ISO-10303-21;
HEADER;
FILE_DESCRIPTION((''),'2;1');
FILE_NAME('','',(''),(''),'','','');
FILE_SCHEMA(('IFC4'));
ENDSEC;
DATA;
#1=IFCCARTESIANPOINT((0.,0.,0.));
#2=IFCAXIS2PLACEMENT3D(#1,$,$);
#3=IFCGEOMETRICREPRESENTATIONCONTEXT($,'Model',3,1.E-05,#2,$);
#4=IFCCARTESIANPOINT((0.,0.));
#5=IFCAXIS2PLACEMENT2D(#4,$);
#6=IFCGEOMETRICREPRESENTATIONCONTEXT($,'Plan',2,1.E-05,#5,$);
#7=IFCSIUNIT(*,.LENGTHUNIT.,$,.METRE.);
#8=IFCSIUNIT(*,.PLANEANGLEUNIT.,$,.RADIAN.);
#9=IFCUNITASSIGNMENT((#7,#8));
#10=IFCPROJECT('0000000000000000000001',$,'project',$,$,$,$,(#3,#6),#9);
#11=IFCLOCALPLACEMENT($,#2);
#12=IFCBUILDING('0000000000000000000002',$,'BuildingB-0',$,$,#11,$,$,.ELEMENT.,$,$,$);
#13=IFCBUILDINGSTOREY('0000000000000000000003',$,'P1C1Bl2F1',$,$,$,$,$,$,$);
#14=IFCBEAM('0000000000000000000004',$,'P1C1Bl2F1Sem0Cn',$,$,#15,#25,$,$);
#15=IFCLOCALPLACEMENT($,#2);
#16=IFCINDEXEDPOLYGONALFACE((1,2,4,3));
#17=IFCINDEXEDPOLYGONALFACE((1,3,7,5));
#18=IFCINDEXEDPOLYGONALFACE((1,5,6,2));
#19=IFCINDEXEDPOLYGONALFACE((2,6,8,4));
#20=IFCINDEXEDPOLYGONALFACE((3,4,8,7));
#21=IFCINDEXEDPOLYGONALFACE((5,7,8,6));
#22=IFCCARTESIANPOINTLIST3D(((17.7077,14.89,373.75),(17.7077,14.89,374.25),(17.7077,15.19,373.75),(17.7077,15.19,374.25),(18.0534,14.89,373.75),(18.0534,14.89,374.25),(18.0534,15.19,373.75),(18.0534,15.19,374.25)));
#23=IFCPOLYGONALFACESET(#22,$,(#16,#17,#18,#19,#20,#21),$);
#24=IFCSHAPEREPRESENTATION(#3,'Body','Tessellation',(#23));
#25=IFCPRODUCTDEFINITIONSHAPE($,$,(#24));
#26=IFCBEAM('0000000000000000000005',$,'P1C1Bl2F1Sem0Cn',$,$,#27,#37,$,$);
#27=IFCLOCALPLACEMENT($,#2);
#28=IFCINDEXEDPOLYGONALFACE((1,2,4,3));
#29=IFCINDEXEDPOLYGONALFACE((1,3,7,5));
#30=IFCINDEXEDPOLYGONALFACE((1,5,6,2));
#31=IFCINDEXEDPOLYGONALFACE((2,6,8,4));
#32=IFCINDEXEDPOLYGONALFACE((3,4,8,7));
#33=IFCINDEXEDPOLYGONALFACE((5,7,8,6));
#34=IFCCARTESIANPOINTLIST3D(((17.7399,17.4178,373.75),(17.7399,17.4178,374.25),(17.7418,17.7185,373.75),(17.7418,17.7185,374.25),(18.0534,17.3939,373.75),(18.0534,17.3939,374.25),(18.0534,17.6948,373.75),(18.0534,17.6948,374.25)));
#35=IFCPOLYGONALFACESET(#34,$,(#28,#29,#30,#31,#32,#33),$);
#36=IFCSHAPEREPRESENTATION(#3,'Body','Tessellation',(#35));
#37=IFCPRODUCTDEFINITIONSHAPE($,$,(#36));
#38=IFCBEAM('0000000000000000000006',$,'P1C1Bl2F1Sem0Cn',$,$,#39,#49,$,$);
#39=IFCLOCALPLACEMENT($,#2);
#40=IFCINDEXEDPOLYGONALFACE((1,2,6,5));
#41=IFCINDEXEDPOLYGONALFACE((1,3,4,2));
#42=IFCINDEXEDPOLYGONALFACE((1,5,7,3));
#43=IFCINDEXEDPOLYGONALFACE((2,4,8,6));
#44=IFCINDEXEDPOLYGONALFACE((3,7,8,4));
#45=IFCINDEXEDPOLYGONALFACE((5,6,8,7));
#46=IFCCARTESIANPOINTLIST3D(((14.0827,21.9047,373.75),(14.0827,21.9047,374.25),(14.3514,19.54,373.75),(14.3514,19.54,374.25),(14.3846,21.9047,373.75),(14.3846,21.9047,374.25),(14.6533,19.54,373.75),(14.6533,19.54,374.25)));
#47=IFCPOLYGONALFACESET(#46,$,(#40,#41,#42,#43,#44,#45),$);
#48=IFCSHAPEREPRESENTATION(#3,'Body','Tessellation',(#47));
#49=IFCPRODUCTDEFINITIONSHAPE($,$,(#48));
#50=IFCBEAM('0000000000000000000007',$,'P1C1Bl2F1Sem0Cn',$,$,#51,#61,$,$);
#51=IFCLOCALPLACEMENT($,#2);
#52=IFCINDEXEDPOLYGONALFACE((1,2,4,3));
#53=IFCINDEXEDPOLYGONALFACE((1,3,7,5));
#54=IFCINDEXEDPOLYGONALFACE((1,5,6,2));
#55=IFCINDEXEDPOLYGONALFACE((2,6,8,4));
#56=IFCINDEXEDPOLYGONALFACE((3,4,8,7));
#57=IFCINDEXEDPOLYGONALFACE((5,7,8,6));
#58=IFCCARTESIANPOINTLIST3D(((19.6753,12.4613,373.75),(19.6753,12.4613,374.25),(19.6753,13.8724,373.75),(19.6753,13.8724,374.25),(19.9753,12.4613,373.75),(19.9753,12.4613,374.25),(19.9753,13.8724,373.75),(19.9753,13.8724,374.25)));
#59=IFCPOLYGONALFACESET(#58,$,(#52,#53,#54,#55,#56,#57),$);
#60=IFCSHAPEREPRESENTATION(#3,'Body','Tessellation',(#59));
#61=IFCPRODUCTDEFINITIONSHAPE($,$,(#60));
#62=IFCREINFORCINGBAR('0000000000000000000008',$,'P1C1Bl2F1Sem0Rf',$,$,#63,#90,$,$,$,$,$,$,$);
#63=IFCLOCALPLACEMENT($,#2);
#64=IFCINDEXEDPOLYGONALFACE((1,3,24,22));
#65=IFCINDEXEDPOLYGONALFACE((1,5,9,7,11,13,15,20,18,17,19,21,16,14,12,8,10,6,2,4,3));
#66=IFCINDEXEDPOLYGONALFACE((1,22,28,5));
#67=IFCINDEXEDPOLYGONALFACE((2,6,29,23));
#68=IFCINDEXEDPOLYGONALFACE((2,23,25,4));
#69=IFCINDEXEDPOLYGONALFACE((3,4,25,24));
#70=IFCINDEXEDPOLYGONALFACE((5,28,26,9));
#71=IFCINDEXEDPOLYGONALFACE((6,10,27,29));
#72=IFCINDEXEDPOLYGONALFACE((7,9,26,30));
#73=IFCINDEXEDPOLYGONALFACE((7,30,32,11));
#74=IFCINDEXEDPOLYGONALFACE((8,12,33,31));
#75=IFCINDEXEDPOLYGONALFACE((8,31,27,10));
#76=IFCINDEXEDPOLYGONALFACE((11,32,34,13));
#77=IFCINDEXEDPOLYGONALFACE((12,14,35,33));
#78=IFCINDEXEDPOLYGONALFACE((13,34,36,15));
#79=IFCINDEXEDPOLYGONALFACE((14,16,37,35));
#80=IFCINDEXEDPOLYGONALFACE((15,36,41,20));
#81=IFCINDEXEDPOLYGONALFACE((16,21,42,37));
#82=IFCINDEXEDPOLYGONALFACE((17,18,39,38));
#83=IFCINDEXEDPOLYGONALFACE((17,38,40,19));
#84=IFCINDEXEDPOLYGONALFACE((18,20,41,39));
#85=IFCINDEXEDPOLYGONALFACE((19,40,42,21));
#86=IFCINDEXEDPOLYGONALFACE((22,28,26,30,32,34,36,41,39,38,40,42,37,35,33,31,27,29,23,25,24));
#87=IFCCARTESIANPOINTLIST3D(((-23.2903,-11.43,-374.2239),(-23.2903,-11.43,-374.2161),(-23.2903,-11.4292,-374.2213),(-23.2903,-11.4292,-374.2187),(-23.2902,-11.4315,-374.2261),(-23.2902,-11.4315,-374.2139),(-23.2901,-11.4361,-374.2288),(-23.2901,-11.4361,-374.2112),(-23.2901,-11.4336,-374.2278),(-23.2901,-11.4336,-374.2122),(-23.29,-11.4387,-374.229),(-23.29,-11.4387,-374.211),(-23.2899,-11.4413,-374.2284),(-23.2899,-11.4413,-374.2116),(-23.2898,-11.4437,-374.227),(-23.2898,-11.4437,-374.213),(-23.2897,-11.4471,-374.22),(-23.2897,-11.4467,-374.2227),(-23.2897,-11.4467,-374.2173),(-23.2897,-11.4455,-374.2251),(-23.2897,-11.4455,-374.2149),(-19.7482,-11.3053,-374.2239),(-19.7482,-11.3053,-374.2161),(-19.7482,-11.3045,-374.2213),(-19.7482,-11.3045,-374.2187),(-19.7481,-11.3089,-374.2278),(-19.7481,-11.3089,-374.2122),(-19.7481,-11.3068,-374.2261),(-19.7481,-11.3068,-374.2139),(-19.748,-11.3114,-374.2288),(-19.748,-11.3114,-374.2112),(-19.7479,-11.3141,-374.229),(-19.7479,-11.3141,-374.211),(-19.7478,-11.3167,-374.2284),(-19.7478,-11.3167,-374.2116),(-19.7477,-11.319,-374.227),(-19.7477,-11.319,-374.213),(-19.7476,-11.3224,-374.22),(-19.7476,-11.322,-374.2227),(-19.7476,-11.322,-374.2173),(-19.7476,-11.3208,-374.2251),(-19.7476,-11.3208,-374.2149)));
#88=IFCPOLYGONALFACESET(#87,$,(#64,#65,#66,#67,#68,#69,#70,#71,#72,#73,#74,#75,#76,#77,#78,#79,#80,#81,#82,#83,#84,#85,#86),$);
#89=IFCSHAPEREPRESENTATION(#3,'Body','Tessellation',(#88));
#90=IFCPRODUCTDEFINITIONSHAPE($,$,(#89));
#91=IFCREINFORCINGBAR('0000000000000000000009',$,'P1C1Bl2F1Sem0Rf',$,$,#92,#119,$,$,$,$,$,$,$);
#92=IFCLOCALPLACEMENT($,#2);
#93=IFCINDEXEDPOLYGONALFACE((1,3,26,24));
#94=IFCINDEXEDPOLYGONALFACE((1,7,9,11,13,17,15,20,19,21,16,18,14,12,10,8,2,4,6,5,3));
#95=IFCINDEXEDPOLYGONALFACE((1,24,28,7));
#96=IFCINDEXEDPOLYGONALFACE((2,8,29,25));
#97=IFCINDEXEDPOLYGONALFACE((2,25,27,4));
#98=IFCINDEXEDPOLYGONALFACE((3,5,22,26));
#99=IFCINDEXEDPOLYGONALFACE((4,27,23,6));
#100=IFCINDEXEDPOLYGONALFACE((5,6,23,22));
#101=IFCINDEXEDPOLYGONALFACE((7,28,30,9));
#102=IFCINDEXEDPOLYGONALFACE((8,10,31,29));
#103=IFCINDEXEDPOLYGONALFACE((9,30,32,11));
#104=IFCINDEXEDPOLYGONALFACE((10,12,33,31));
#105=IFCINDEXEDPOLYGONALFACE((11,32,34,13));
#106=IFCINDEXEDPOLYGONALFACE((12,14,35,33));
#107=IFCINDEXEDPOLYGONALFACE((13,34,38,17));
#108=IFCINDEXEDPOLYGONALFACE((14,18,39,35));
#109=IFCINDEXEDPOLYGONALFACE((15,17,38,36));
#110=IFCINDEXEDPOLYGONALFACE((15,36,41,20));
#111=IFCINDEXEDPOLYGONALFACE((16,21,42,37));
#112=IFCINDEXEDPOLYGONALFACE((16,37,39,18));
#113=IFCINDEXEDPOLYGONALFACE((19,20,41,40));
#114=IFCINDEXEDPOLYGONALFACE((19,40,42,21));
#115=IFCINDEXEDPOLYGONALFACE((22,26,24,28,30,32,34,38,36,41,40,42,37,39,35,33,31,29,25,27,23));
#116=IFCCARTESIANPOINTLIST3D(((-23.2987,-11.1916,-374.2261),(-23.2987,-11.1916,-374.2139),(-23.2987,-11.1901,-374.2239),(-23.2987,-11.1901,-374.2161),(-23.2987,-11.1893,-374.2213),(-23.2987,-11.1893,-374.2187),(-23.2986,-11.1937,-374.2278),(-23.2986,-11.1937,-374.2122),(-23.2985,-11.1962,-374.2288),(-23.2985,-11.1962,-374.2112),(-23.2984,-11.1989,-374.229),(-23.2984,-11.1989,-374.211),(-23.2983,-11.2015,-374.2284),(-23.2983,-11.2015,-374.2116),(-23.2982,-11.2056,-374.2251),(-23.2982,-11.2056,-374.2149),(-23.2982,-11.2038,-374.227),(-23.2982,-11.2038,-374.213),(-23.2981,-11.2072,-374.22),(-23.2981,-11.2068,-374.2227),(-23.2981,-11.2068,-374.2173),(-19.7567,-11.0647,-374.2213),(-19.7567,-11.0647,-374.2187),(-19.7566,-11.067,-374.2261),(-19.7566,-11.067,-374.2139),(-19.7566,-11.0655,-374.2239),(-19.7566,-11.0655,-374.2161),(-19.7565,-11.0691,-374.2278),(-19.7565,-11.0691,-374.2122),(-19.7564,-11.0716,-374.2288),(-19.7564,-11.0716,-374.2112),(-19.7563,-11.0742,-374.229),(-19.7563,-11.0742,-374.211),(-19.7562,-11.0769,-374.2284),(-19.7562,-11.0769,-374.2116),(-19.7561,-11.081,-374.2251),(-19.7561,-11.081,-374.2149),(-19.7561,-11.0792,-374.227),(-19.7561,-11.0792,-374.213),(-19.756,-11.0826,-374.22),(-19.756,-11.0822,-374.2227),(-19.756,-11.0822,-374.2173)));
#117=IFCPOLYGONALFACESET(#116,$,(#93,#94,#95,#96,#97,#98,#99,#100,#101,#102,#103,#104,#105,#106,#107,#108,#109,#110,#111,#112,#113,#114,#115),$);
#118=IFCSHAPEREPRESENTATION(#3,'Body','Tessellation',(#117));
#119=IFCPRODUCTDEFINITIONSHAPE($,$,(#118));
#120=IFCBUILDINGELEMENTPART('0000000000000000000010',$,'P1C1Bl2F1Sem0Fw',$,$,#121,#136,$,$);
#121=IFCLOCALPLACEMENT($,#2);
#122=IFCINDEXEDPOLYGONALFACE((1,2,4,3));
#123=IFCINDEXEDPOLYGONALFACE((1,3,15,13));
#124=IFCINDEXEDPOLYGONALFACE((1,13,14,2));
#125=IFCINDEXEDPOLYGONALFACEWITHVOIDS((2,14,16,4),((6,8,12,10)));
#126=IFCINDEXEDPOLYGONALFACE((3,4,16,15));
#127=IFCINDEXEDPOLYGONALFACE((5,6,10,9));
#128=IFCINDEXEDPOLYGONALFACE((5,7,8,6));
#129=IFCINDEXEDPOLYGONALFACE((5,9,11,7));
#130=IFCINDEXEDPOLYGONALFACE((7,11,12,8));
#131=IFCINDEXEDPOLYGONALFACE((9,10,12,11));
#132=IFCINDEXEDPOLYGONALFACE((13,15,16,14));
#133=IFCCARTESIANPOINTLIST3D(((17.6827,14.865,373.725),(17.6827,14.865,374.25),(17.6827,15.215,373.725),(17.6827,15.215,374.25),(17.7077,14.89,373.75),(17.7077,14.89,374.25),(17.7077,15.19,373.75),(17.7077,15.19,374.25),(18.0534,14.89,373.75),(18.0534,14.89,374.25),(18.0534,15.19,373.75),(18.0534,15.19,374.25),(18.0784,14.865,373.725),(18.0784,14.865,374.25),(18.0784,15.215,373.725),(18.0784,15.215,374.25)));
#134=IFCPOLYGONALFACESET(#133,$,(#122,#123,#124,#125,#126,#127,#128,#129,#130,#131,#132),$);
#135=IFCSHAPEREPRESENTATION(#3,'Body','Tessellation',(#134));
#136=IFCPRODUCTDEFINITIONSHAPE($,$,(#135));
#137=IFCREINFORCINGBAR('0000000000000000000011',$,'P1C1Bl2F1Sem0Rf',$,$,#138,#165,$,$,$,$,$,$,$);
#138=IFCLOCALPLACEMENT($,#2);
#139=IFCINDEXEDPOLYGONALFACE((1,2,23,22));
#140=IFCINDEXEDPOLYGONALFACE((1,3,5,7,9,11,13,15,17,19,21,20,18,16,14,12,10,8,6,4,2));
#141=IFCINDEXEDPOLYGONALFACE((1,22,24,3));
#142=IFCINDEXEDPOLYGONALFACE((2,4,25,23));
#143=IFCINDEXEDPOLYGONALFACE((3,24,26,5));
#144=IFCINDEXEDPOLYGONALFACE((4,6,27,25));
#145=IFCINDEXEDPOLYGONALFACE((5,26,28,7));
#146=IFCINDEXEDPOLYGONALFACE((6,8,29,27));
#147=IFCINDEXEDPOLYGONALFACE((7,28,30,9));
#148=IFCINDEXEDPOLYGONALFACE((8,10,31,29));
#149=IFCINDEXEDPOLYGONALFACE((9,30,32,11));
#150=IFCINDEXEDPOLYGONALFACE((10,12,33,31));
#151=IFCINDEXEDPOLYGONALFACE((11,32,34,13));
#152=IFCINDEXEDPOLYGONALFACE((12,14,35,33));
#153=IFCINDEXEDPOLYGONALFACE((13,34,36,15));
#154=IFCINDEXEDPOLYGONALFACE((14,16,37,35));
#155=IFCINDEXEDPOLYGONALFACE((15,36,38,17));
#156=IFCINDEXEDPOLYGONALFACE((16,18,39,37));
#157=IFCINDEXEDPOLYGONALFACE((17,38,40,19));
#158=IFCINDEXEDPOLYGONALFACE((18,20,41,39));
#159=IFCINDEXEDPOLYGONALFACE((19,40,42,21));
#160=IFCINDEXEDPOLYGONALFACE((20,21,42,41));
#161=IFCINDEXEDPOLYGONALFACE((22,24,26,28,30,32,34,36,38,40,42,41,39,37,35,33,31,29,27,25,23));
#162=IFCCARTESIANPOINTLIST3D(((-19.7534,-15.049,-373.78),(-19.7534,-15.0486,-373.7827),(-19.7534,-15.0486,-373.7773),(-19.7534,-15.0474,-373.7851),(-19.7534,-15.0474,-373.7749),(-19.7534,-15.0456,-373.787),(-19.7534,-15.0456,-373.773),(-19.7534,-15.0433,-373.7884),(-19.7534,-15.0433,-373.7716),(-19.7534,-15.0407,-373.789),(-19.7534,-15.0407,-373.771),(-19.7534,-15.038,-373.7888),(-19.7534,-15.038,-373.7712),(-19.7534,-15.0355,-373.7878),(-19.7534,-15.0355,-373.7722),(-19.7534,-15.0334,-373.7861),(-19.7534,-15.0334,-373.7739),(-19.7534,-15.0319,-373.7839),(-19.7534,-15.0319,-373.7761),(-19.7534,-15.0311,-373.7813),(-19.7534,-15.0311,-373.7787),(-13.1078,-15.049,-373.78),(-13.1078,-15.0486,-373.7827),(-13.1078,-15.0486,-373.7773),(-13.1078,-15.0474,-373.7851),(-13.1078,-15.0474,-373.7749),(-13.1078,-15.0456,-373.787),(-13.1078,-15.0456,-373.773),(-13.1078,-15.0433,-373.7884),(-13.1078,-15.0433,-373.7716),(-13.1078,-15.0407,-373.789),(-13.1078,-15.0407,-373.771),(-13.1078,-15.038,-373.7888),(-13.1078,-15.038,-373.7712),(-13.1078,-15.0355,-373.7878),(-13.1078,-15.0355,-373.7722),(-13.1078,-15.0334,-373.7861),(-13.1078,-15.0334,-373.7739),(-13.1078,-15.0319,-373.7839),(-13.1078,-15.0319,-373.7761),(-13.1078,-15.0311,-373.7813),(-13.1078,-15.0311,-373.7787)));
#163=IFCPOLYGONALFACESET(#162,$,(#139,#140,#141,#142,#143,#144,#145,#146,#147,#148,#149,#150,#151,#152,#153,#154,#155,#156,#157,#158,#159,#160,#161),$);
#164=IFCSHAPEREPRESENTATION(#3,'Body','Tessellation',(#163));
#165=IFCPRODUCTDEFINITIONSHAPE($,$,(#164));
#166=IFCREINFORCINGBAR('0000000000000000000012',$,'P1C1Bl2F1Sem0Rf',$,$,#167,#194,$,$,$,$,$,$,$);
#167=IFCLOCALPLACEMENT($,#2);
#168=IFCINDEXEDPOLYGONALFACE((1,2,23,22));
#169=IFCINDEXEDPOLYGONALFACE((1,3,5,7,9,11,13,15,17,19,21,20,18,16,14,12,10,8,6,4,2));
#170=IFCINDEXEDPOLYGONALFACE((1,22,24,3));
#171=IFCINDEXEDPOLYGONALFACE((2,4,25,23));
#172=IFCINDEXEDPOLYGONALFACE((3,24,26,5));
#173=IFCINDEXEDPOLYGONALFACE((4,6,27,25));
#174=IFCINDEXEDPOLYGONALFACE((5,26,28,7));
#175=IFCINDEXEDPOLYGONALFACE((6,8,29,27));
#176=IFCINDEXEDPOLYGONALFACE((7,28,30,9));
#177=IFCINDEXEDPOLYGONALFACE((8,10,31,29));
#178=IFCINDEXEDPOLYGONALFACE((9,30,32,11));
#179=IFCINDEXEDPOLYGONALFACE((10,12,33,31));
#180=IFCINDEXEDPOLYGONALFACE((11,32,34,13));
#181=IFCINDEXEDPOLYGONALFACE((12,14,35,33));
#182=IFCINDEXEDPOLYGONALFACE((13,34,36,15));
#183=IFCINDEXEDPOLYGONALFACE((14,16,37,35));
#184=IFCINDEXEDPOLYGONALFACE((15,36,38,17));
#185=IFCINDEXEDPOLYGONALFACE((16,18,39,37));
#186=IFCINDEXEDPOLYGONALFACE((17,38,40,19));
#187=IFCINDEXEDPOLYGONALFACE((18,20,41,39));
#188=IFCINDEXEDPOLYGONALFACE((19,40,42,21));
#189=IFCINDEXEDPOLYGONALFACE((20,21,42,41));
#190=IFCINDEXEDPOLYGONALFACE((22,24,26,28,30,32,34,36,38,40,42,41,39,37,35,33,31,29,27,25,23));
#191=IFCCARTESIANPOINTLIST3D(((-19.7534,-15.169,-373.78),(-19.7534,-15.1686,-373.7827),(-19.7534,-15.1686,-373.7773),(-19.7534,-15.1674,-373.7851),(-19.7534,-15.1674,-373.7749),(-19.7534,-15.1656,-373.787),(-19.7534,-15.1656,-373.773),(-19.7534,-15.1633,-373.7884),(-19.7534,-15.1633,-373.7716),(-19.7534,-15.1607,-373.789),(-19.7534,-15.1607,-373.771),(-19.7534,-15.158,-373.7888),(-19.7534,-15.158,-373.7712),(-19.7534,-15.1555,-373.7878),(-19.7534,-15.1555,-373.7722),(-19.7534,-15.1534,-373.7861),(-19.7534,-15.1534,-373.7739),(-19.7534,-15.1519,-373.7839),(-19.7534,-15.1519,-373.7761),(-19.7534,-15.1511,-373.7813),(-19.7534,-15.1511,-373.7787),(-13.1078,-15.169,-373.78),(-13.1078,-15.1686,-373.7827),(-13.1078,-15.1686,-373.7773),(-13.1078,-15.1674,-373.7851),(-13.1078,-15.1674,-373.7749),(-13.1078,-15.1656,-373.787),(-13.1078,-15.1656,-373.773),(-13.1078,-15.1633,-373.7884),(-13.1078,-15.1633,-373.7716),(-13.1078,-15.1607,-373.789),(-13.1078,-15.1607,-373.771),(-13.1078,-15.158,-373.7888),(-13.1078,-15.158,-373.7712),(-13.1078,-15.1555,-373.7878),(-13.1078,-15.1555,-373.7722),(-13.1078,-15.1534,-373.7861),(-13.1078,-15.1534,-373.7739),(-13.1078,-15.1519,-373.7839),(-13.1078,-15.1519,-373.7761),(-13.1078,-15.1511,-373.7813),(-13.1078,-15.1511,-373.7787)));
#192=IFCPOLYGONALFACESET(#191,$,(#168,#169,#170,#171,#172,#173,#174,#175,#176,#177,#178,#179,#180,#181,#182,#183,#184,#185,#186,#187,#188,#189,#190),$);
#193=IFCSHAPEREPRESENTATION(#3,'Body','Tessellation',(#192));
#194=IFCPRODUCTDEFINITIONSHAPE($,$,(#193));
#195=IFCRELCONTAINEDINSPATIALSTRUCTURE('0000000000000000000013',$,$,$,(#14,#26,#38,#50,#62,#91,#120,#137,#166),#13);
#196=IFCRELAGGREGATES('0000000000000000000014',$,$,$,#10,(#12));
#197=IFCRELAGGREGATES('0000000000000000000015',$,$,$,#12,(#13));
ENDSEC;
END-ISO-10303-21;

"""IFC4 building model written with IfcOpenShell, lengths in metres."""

from ifc_helpers import new_model, entity, si_unit, origin, origin_2d, place, context, project, spatial, polyline, outline, extrude, element, save


model = new_model("IFC4")

# Units and contexts
model_context = context("Model", 3, precision=1e-05, world=origin())
plan_context = context("Plan", 2, precision=1e-05, world=origin_2d())
ifc_project = project(units=[si_unit("LENGTHUNIT", "METRE"), si_unit("PLANEANGLEUNIT", "RADIAN")], contexts=[model_context, plan_context])

# Building, storey
building_placement = place(None, origin())
building = spatial("IfcBuilding", under=ifc_project, at=building_placement, Name="BuildingB-0", CompositionType="ELEMENT")
storey = spatial("IfcBuildingStorey", under=building, Name="P1C1Bl2F1")

# Beams
element("IfcBeam", 1, inside=storey, Name="P1C1Bl2F1Sem0Cn", context=model_context, shape_type="SweptSolid", body=[
    extrude(outline(polyline([(17.7077, 15.19, 373.75), (18.0534, 15.19, 373.75), (18.0534, 14.89, 373.75), (17.7077, 14.89, 373.75), (17.7077, 15.19, 373.75)])), None, (0.0, 0.0, 1.0), 0.5),
])
element("IfcBeam", 2, inside=storey, Name="P1C1Bl2F1Sem0Cn", context=model_context, shape_type="SweptSolid", body=[
    extrude(outline(polyline([(17.7399, 17.4178, 373.75), (18.0534, 17.3939, 373.75), (18.0534, 17.6948, 373.75), (17.7418, 17.7185, 373.75), (17.7399, 17.4178, 373.75)])), None, (0.0, 0.0, 1.0), 0.5),
])
element("IfcBeam", 3, inside=storey, Name="P1C1Bl2F1Sem0Cn", context=model_context, shape_type="SweptSolid", body=[
    extrude(outline(polyline([(14.3514, 19.54, 373.75), (14.6533, 19.54, 373.75), (14.3846, 21.9047, 373.75), (14.0827, 21.9047, 373.75), (14.3514, 19.54, 373.75)])), None, (0.0, 0.0, 1.0), 0.5),
])
element("IfcBeam", 4, inside=storey, Name="P1C1Bl2F1Sem0Cn", context=model_context, shape_type="SweptSolid", body=[
    extrude(outline(polyline([(19.6753, 12.4613, 373.75), (19.9753, 12.4613, 373.75), (19.9753, 13.8724, 373.75), (19.6753, 13.8724, 373.75), (19.6753, 12.4613, 373.75)])), None, (0.0, 0.0, 1.0), 0.5),
])

# Reinforcing bars
element("IfcReinforcingBar", 5, inside=storey, Name="P1C1Bl2F1Sem0Rf", context=model_context, shape_type="SweptSolid", body=[
    entity("IfcSurfaceCurveSweptAreaSolid", entity("IfcCircleProfileDef", "AREA", None, None, 0.009), None, entity("IfcPolyline", [entity("IfcCartesianPoint", [23.29, 11.4381, 374.22]), entity("IfcCartesianPoint", [19.7479, 11.3134, 374.22])]), None, None, entity("IfcPlane", entity("IfcAxis2Placement3D", entity("IfcCartesianPoint", [23.29, 11.4381, 374.22]), entity("IfcDirection", [0.0, 0.0, 1.0]), entity("IfcDirection", [1.0, 0.0, 0.0])))),
])
element("IfcReinforcingBar", 6, inside=storey, Name="P1C1Bl2F1Sem0Rf", context=model_context, shape_type="SweptSolid", body=[
    entity("IfcSurfaceCurveSweptAreaSolid", entity("IfcCircleProfileDef", "AREA", None, None, 0.009), None, entity("IfcPolyline", [entity("IfcCartesianPoint", [23.2984, 11.1982, 374.22]), entity("IfcCartesianPoint", [19.7563, 11.0736, 374.22])]), None, None, entity("IfcPlane", entity("IfcAxis2Placement3D", entity("IfcCartesianPoint", [23.2984, 11.1982, 374.22]), entity("IfcDirection", [0.0, 0.0, 1.0]), entity("IfcDirection", [1.0, 0.0, 0.0])))),
])

# Building element part, opening
building_element_part_1 = element("IfcBuildingElementPart", 7, inside=storey, Name="P1C1Bl2F1Sem0Fw", context=model_context, shape_type="SweptSolid", body=[
    extrude(outline(polyline([(17.6827, 15.215, 373.725), (18.0784, 15.215, 373.725), (18.0784, 14.865, 373.725), (17.6827, 14.865, 373.725), (17.6827, 15.215, 373.725)])), None, (0.0, 0.0, 1.0), 0.525),
])
element("IfcOpeningElement", 8, inside=storey, cuts=building_element_part_1, context=model_context, shape_type="SweptSolid", body=[
    extrude(outline(polyline([(17.7077, 15.19, 373.75), (18.0534, 15.19, 373.75), (18.0534, 14.89, 373.75), (17.7077, 14.89, 373.75), (17.7077, 15.19, 373.75)])), None, (0.0, 0.0, 1.0), 0.5),
])

# Reinforcing bars
element("IfcReinforcingBar", 9, inside=storey, Name="P1C1Bl2F1Sem0Rf", context=model_context, shape_type="SweptSolid", body=[
    entity("IfcSurfaceCurveSweptAreaSolid", entity("IfcCircleProfileDef", "AREA", None, None, 0.009), None, entity("IfcPolyline", [entity("IfcCartesianPoint", [19.7534, 15.04, 373.78]), entity("IfcCartesianPoint", [13.1078, 15.04, 373.78])]), None, None, entity("IfcPlane", entity("IfcAxis2Placement3D", entity("IfcCartesianPoint", [19.7534, 15.04, 373.78]), entity("IfcDirection", [0.0, 0.0, 1.0]), entity("IfcDirection", [1.0, 0.0, 0.0])))),
])
element("IfcReinforcingBar", 10, inside=storey, Name="P1C1Bl2F1Sem0Rf", context=model_context, shape_type="SweptSolid", body=[
    entity("IfcSurfaceCurveSweptAreaSolid", entity("IfcCircleProfileDef", "AREA", None, None, 0.009), None, entity("IfcPolyline", [entity("IfcCartesianPoint", [19.7534, 15.16, 373.78]), entity("IfcCartesianPoint", [13.1078, 15.16, 373.78])]), None, None, entity("IfcPlane", entity("IfcAxis2Placement3D", entity("IfcCartesianPoint", [19.7534, 15.16, 373.78]), entity("IfcDirection", [0.0, 0.0, 1.0]), entity("IfcDirection", [1.0, 0.0, 0.0])))),
])

save(model, "model.ifc")
